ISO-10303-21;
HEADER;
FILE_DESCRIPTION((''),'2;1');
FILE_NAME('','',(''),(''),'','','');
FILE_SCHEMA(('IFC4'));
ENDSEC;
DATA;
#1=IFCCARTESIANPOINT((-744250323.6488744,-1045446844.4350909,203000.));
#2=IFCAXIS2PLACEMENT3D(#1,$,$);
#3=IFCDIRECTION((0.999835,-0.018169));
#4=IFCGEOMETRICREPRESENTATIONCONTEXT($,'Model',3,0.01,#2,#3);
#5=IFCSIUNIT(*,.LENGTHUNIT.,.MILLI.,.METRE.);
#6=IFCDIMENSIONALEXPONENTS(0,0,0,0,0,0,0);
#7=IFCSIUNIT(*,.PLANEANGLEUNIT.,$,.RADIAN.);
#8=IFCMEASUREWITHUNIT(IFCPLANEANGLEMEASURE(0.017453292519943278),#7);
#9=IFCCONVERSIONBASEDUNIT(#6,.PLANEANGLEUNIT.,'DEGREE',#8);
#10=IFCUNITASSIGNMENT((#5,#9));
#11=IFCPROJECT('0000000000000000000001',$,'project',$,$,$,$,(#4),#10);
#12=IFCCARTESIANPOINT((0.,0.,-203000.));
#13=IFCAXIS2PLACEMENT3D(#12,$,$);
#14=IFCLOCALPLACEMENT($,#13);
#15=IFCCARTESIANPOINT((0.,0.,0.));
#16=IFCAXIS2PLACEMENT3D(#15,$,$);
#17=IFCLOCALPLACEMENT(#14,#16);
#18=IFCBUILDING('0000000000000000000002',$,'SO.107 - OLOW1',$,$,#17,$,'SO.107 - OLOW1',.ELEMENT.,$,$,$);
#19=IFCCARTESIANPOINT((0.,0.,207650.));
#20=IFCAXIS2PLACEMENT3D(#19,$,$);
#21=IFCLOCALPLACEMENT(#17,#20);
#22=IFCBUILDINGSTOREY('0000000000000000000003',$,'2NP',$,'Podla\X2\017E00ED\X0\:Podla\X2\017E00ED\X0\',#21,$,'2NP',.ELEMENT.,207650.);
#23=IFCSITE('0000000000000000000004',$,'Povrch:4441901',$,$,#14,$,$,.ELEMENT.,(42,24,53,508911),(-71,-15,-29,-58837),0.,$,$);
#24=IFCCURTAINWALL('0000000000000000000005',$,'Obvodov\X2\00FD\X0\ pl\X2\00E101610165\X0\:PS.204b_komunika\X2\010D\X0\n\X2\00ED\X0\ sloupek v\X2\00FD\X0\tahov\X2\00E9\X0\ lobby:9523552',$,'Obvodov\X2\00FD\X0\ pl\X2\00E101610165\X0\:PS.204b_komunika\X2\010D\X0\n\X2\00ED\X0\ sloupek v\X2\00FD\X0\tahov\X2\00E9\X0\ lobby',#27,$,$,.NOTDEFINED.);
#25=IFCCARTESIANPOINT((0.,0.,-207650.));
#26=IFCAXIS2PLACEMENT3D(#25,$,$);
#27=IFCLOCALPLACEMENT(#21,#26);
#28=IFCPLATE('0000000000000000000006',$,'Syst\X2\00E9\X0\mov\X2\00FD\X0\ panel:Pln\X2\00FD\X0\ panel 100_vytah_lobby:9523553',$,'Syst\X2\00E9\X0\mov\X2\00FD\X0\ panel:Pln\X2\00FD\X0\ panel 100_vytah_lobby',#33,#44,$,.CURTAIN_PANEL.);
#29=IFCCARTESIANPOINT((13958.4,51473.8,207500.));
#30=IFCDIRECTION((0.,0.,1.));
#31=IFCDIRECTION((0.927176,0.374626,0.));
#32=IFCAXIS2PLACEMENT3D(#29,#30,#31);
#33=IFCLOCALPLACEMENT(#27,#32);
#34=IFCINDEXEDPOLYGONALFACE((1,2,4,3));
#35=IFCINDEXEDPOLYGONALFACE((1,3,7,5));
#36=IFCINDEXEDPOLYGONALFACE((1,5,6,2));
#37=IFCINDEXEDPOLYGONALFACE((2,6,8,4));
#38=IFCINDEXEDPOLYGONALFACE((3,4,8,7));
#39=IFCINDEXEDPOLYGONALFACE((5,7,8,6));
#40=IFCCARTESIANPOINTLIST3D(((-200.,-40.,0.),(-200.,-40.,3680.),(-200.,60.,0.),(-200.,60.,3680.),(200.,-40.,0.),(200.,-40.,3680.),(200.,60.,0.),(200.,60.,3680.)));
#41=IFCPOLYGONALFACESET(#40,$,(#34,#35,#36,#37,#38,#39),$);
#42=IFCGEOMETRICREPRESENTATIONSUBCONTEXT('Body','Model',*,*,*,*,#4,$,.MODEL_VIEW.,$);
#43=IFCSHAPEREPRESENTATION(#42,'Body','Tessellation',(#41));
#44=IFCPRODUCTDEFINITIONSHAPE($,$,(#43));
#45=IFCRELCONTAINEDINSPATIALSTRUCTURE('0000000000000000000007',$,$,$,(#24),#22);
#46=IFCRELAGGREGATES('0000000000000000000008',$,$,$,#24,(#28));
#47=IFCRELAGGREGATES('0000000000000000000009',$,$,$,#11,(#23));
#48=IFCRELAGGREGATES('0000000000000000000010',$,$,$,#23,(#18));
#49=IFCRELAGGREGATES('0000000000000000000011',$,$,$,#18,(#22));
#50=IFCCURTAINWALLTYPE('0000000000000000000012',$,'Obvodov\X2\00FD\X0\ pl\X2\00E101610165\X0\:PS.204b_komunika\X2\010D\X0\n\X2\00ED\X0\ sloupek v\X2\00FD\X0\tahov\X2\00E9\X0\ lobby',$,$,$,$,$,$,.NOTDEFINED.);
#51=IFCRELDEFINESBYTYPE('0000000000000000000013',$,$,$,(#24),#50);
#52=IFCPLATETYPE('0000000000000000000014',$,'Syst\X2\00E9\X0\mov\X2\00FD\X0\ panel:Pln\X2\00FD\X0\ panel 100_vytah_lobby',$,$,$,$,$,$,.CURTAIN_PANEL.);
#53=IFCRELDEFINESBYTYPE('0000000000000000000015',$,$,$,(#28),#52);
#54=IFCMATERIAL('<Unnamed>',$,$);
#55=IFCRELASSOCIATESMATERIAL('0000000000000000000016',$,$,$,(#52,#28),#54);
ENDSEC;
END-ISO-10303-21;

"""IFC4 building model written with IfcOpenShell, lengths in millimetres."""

from ifc_helpers import new_model, entity, si_unit, converted_unit, direction, frame, origin, place, context, subcontext, project, spatial, indexed_curve, outline, extrude, source, transform, mapped, material, type_object, type_shapes, element, aggregate, save


model = new_model("IFC4")

# Units and contexts
model_context = context("Model", 3, precision=0.01, world=frame((-744250323.6488744, -1045446844.4350909, 203000.0)), true_north=direction((0.999835, -0.018169)))
body_context = subcontext(model_context, "Body", "Model", "MODEL_VIEW")
ifc_project = project(units=[si_unit("LENGTHUNIT", "METRE", prefix="MILLI"), converted_unit("PLANEANGLEUNIT", "DEGREE", entity("IfcPlaneAngleMeasure", 0.017453292519943278), si_unit("PLANEANGLEUNIT", "RADIAN"), dimensions=[0, 0, 0, 0, 0, 0, 0])], contexts=[model_context])

# Site, building, storey
site_placement = place(None, frame((0.0, 0.0, -203000.0)))
site = spatial("IfcSite", under=ifc_project, at=site_placement, Name="Povrch:4441901", CompositionType="ELEMENT", RefLatitude=(42, 24, 53, 508911), RefLongitude=(-71, -15, -29, -58837), RefElevation=0.0)
building_placement = place(site_placement, origin())
building = spatial("IfcBuilding", under=site, at=building_placement, Name="SO.107 - OLOW1", LongName="SO.107 - OLOW1", CompositionType="ELEMENT")
storey_placement = place(building_placement, frame((0.0, 0.0, 207650.0)))
storey = spatial("IfcBuildingStorey", under=building, at=storey_placement, Name="2NP", ObjectType="Podlaží:Podlaží", LongName="2NP", CompositionType="ELEMENT", Elevation=207650.0)

# Shared definitions
ifc_material_1 = material(Name="<Unnamed>")

# Curtain wall, plate
curtain_wall_type_1 = type_object("IfcCurtainWallType", Name="Obvodový plášť:PS.204b_komunikační sloupek výtahové lobby", PredefinedType="NOTDEFINED")
curtain_wall_1_placement = place(storey_placement, frame((0.0, 0.0, -207650.0)))
curtain_wall_1 = element("IfcCurtainWall", 1, at=curtain_wall_1_placement, inside=storey, type_object=curtain_wall_type_1, Name="Obvodový plášť:PS.204b_komunikační sloupek výtahové lobby:9523552", ObjectType="Obvodový plášť:PS.204b_komunikační sloupek výtahové lobby", PredefinedType="NOTDEFINED")
plate_type_1 = type_object("IfcPlateType", Name="Systémový panel:Plný panel 100_vytah_lobby", PredefinedType="CURTAIN_PANEL", material=ifc_material_1)
shared_shape_1 = source(origin(), body_context, "Body", "SweptSolid", [
    extrude(outline(indexed_curve([(-50.0, -200.0), (50.0, -200.0), (50.0, 200.0), (-50.0, 200.0), (-50.0, -200.0)], self_intersect=False)), frame((0.0, 10.0, 0.0), z_axis=(0.0, 0.0, 1.0), x_axis=(0.0, 1.0, 0.0)), (0.0, 0.0, 1.0), 3680.0),
])
type_shapes(plate_type_1, [shared_shape_1])
plate_1_placement = place(curtain_wall_1_placement, frame((13958.4, 51473.8, 207500.0), z_axis=(0.0, 0.0, 1.0), x_axis=(0.927176, 0.374626, 0.0)))
plate_1 = element("IfcPlate", 2, at=plate_1_placement, type_object=plate_type_1, material=ifc_material_1, Name="Systémový panel:Plný panel 100_vytah_lobby:9523553", ObjectType="Systémový panel:Plný panel 100_vytah_lobby", PredefinedType="CURTAIN_PANEL", context=body_context, shape_type="MappedRepresentation", body=[
    mapped(shared_shape_1, transform((0.0, 0.0, 0.0), scale=1.0)),
])
aggregate(curtain_wall_1, [plate_1])

save(model, "model.ifc")
